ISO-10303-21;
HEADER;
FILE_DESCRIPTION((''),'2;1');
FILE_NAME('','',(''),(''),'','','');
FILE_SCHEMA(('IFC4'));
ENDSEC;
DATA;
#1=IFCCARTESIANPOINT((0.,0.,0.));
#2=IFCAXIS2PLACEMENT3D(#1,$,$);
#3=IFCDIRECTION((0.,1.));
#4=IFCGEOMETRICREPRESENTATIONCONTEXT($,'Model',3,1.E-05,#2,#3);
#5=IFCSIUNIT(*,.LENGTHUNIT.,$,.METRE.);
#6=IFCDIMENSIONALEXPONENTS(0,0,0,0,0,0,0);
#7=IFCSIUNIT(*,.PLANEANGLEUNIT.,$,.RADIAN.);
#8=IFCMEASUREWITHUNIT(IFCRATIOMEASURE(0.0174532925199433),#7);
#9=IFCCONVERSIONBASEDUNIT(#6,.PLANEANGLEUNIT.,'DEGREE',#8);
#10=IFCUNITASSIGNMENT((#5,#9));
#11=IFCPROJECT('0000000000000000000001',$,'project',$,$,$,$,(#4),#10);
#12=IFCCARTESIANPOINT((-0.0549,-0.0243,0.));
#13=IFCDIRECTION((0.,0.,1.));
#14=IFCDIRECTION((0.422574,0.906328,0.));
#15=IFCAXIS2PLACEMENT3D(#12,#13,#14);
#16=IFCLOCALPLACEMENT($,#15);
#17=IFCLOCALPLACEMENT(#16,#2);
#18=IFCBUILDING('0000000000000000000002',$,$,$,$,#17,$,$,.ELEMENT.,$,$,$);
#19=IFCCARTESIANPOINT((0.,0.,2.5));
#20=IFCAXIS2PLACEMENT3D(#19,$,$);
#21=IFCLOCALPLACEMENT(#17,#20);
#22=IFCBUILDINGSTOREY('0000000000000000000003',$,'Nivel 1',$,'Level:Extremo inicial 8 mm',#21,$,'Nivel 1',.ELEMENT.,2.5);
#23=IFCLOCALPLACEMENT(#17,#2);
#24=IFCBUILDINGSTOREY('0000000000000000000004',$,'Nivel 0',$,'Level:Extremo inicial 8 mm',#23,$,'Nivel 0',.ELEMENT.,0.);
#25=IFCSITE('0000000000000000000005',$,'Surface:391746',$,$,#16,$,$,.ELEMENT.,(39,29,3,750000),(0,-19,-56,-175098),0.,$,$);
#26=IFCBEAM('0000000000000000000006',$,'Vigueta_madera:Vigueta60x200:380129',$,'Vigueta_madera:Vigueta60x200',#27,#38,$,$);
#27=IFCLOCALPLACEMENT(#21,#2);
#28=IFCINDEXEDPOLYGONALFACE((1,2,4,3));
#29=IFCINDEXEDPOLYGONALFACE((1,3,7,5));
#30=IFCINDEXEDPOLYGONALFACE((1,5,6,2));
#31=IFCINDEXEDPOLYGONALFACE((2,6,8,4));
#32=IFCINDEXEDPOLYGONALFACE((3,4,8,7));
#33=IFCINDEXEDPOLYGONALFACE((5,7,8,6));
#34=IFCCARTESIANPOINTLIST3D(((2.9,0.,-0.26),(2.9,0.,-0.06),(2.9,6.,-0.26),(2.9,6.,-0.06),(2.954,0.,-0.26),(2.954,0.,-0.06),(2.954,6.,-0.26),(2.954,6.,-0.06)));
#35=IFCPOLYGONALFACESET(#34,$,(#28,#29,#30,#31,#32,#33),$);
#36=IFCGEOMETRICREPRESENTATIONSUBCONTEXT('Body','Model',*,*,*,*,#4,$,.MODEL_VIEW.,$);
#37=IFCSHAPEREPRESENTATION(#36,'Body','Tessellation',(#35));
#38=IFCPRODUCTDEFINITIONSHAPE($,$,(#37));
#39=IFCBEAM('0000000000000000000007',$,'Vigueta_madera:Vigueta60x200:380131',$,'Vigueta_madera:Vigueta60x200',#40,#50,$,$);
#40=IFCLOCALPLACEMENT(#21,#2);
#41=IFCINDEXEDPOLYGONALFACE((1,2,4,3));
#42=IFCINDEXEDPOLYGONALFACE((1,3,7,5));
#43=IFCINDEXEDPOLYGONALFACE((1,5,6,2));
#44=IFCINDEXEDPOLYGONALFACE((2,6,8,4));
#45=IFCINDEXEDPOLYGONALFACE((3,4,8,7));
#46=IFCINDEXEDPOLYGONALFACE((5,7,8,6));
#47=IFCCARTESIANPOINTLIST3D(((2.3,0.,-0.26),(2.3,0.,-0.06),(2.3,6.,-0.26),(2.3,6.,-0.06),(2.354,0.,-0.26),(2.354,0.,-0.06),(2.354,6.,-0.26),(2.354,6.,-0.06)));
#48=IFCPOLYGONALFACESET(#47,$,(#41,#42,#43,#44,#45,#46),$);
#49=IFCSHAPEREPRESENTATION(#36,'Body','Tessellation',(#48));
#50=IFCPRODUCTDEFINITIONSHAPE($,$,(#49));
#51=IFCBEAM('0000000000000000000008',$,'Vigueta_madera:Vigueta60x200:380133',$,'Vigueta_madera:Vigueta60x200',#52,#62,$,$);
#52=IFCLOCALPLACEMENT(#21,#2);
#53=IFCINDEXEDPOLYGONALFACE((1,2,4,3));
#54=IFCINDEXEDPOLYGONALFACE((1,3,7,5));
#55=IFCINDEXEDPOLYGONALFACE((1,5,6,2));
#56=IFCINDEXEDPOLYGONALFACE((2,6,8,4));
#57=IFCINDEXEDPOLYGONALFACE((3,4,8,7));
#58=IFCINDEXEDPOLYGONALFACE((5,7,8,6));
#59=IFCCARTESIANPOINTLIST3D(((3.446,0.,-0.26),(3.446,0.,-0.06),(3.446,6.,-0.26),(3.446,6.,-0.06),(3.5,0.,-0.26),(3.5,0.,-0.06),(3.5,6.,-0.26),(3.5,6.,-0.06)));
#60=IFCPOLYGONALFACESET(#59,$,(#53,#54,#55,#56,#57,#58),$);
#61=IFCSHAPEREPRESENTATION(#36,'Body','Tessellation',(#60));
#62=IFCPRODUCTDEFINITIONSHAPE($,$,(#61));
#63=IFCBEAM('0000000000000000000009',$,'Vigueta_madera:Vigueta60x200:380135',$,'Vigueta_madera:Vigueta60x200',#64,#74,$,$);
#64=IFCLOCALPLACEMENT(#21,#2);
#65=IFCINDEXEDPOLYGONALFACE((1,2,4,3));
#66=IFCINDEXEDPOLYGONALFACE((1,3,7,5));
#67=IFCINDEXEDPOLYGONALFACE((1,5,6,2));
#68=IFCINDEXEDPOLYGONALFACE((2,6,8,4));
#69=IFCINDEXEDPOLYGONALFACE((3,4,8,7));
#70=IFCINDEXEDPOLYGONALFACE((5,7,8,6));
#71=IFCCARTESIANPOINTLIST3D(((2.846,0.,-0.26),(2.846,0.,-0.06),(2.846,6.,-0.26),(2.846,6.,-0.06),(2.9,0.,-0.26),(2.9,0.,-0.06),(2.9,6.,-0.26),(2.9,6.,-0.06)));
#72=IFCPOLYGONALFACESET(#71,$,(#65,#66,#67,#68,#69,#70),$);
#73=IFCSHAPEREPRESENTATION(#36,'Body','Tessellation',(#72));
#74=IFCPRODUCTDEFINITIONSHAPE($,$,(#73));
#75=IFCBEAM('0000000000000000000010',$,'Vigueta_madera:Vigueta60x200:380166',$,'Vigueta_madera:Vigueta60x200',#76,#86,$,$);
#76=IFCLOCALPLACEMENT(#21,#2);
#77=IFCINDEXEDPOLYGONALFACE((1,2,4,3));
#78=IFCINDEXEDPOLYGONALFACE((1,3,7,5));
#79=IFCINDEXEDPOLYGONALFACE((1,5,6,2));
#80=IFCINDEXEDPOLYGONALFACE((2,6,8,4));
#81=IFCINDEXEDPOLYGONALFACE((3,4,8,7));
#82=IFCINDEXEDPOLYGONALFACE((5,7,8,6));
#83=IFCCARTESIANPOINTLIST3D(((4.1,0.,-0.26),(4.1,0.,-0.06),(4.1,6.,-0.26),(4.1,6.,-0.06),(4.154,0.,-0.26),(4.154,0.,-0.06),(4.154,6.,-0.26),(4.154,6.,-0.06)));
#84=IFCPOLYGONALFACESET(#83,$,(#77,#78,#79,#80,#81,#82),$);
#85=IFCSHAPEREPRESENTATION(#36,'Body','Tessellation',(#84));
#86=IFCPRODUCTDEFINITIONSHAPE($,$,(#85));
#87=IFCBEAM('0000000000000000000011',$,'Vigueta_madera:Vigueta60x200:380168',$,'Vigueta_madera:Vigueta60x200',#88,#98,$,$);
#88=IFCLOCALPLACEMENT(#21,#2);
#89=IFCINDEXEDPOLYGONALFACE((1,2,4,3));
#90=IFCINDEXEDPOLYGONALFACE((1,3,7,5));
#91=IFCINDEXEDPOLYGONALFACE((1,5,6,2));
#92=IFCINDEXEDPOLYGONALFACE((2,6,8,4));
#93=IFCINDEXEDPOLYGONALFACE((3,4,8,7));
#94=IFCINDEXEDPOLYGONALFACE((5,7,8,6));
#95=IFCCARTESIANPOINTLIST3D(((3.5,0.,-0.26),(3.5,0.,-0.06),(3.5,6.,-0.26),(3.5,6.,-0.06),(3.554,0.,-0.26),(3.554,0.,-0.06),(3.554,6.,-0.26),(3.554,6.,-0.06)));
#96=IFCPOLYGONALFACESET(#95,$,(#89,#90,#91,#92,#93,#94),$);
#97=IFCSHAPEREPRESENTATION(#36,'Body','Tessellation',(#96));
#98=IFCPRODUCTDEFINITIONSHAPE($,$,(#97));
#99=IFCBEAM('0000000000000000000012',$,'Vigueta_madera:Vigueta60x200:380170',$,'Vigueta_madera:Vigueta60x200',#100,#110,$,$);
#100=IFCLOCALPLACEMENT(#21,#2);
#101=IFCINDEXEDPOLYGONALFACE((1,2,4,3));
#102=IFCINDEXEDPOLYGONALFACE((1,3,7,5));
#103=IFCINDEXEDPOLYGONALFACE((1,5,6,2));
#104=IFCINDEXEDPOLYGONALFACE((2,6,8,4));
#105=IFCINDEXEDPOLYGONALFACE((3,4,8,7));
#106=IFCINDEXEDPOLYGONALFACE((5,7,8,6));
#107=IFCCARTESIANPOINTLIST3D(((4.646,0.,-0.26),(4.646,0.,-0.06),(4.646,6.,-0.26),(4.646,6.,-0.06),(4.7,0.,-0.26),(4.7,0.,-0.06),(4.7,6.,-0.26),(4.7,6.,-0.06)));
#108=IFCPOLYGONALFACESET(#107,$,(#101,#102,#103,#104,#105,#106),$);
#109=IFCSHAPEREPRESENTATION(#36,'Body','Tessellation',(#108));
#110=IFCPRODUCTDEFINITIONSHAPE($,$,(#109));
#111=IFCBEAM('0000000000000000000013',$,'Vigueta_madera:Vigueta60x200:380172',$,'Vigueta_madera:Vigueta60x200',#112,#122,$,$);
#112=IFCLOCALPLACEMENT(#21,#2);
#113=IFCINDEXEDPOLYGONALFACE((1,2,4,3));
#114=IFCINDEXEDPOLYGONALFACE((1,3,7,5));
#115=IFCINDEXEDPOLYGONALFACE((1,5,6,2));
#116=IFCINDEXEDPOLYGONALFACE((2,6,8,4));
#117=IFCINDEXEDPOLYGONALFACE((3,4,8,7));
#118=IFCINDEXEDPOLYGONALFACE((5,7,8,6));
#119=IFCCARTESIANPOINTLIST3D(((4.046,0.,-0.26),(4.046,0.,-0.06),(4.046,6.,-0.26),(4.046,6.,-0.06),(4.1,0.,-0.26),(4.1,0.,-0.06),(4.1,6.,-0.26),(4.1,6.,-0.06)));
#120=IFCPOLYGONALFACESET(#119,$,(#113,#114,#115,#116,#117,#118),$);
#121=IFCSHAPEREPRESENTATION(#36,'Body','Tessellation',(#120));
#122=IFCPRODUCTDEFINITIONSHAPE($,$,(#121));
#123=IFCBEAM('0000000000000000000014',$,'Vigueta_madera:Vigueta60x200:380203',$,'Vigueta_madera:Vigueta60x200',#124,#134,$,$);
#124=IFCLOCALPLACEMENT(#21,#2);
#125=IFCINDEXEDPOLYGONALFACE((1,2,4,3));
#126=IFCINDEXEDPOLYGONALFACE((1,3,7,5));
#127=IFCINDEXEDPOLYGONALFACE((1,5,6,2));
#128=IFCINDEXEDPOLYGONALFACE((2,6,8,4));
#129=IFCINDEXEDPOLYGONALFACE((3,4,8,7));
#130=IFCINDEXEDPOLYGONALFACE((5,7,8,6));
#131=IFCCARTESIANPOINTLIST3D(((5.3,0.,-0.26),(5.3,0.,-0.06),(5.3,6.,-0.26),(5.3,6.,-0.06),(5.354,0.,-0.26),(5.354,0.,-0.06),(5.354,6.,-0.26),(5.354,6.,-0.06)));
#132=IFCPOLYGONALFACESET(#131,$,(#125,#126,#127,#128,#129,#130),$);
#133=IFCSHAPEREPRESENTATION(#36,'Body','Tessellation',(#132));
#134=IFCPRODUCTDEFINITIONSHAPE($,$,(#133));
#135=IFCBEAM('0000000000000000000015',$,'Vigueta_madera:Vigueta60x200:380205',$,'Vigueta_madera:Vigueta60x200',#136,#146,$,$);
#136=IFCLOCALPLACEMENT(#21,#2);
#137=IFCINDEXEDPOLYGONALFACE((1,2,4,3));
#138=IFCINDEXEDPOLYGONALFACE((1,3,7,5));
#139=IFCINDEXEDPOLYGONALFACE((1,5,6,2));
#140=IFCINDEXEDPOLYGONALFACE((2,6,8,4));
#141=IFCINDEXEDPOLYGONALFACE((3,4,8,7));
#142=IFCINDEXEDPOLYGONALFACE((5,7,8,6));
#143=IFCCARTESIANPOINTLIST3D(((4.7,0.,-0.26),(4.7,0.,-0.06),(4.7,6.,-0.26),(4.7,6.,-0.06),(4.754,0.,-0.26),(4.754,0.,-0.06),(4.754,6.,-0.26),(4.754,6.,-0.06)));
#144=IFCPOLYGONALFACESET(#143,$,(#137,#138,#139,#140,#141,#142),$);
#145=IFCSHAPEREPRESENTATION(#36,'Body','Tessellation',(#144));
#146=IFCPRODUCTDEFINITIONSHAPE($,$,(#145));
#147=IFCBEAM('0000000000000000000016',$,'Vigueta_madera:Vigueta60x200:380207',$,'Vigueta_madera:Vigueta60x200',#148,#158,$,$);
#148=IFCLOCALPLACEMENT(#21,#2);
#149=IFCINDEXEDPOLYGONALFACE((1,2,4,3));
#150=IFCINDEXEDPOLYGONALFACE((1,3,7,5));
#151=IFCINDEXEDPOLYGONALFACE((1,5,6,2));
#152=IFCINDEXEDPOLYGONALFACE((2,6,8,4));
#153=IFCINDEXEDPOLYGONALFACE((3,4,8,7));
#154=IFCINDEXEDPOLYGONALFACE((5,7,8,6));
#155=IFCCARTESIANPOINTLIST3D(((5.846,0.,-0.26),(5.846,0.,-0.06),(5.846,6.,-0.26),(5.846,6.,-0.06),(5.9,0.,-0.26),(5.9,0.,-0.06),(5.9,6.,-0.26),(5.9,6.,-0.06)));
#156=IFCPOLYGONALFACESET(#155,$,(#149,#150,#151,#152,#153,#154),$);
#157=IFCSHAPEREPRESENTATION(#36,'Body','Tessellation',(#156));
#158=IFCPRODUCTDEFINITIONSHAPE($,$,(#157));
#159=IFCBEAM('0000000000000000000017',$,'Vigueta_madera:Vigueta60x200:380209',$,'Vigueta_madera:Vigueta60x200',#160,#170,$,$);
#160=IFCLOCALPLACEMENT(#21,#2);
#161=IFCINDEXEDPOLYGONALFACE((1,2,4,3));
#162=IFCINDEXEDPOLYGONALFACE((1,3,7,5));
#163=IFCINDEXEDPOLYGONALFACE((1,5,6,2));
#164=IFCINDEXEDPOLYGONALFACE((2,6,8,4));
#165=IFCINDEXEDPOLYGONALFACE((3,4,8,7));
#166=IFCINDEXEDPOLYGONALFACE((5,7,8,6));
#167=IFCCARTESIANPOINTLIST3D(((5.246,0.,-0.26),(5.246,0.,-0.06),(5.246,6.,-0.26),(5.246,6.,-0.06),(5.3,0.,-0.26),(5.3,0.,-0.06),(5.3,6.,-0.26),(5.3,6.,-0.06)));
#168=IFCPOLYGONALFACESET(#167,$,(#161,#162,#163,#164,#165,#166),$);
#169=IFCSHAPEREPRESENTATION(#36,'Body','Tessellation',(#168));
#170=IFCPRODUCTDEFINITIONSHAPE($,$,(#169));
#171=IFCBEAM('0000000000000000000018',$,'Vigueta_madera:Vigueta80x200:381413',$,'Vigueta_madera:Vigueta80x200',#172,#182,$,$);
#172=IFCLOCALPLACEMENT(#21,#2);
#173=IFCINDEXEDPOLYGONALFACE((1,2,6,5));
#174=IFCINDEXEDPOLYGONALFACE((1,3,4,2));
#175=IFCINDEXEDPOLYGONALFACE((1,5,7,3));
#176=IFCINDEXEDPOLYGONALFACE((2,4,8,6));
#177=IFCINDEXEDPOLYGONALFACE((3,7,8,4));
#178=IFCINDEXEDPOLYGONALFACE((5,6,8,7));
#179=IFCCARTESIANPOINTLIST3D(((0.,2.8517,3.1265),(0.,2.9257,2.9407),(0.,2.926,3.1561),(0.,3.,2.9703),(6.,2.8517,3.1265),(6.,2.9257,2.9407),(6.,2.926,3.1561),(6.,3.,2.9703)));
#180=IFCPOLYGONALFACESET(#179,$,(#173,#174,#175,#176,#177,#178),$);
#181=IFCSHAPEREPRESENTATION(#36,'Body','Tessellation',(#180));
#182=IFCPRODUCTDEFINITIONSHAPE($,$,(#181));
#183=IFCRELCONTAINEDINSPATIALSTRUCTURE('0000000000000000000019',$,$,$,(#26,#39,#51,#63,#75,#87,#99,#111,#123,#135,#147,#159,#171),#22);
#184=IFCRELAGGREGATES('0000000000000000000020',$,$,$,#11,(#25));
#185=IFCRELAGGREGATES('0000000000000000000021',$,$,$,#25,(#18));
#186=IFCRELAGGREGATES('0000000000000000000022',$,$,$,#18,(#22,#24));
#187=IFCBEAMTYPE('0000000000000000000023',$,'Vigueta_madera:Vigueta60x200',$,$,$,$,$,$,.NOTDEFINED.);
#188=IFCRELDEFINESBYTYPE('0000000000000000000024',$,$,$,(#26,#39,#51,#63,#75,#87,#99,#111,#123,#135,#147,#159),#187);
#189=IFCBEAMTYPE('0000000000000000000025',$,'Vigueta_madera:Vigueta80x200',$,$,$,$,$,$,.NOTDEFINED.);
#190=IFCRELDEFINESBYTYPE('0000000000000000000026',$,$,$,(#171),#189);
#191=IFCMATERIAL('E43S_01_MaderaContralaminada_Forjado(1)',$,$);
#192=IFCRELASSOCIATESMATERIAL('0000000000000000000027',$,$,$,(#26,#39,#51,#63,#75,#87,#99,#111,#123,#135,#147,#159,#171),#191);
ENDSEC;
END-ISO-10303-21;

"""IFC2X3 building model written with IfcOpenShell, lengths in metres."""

from ifc_helpers import new_model, entity, si_unit, converted_unit, direction, frame, frame_2d, origin, place, context, subcontext, project, spatial, rectangle, extrude, material, type_object, element, save


model = new_model("IFC2X3")

# Units and contexts
model_context = context("Model", 3, precision=1e-05, world=origin(), true_north=direction((0.0, 1.0)))
body_context = subcontext(model_context, "Body", "Model", "MODEL_VIEW")
ifc_project = project(units=[si_unit("LENGTHUNIT", "METRE"), converted_unit("PLANEANGLEUNIT", "DEGREE", entity("IfcRatioMeasure", 0.0174532925199433), si_unit("PLANEANGLEUNIT", "RADIAN"), dimensions=[0, 0, 0, 0, 0, 0, 0])], contexts=[model_context])

# Site, building, storey
site_placement = place(None, frame((-0.0549, -0.0243, 0.0), z_axis=(0.0, 0.0, 1.0), x_axis=(0.422574, 0.906328, 0.0)))
site = spatial("IfcSite", under=ifc_project, at=site_placement, Name="Surface:391746", CompositionType="ELEMENT", RefLatitude=(39, 29, 3, 750000), RefLongitude=(0, -19, -56, -175098), RefElevation=0.0)
building_placement = place(site_placement, origin())
building = spatial("IfcBuilding", under=site, at=building_placement, CompositionType="ELEMENT")
storey_1_placement = place(building_placement, frame((0.0, 0.0, 2.5)))
storey_1 = spatial("IfcBuildingStorey", under=building, at=storey_1_placement, Name="Nivel 1", ObjectType="Level:Extremo inicial 8 mm", LongName="Nivel 1", CompositionType="ELEMENT", Elevation=2.5)

# Beams
ifc_material_1 = material(Name="E43S_01_MaderaContralaminada_Forjado(1)")
beam_type_1 = type_object("IfcBeamType", Name="Vigueta_madera:Vigueta60x200", PredefinedType="NOTDEFINED")
beam_1_placement = place(storey_1_placement, frame((2.927, 0.0, -0.06), z_axis=(0.0, 0.0, 1.0), x_axis=(0.0, 1.0, 0.0)))
element("IfcBeam", 1, at=beam_1_placement, inside=storey_1, type_object=beam_type_1, material=ifc_material_1, Name="Vigueta_madera:Vigueta60x200:380129", ObjectType="Vigueta_madera:Vigueta60x200", context=body_context, shape_type="SweptSolid", body=[
    extrude(rectangle(XDim=0.2, YDim=0.054, at=frame_2d((0.0, 0.0), x_axis=(1.0, 0.0))), frame((0.0, 0.0, -0.1), z_axis=(1.0, 0.0, 0.0), x_axis=(0.0, 0.0, -1.0)), (0.0, 0.0, 1.0), 6.0),
])
for number, where, z_axis, x_axis, name in (
    (2, (2.327, 0.0, -0.06), (0.0, 0.0, 1.0), (0.0, 1.0, 0.0), "Vigueta_madera:Vigueta60x200:380131"),
    (3, (3.473, 0.0, -0.06), (0.0, 0.0, 1.0), (0.0, 1.0, 0.0), "Vigueta_madera:Vigueta60x200:380133"),
):
    element("IfcBeam", number, at=place(storey_1_placement, frame(where, z_axis=z_axis, x_axis=x_axis)), inside=storey_1, type_object=beam_type_1, material=ifc_material_1, Name=name, ObjectType="Vigueta_madera:Vigueta60x200", context=body_context, shape_type="SweptSolid", body=[
        extrude(rectangle(XDim=0.2, YDim=0.054, at=frame_2d((0.0, 0.0), x_axis=(1.0, 0.0))), frame((0.0, 0.0, -0.1), z_axis=(1.0, 0.0, 0.0), x_axis=(0.0, 0.0, -1.0)), (0.0, 0.0, 1.0), 6.0),
    ])
for number, where, z_axis, x_axis, name in (
    (4, (2.873, 0.0, -0.06), (0.0, 0.0, 1.0), (0.0, 1.0, 0.0), "Vigueta_madera:Vigueta60x200:380135"),
    (5, (4.127, 0.0, -0.06), (0.0, 0.0, 1.0), (0.0, 1.0, 0.0), "Vigueta_madera:Vigueta60x200:380166"),
):
    element("IfcBeam", number, at=place(storey_1_placement, frame(where, z_axis=z_axis, x_axis=x_axis)), inside=storey_1, type_object=beam_type_1, material=ifc_material_1, Name=name, ObjectType="Vigueta_madera:Vigueta60x200", context=body_context, shape_type="SweptSolid", body=[
        extrude(rectangle(XDim=0.2, YDim=0.054, at=frame_2d((0.0, 0.0), x_axis=(1.0, 0.0))), frame((0.0, 0.0, -0.1), z_axis=(1.0, 0.0, 0.0), x_axis=(0.0, 0.0, -1.0)), (0.0, 0.0, 1.0), 6.0),
    ])
beam_2_placement = place(storey_1_placement, frame((3.527, 0.0, -0.06), z_axis=(0.0, 0.0, 1.0), x_axis=(0.0, 1.0, 0.0)))
element("IfcBeam", 6, at=beam_2_placement, inside=storey_1, type_object=beam_type_1, material=ifc_material_1, Name="Vigueta_madera:Vigueta60x200:380168", ObjectType="Vigueta_madera:Vigueta60x200", context=body_context, shape_type="SweptSolid", body=[
    extrude(rectangle(XDim=0.2, YDim=0.054, at=frame_2d((0.0, 0.0), x_axis=(1.0, 0.0))), frame((0.0, 0.0, -0.1), z_axis=(1.0, 0.0, 0.0), x_axis=(0.0, 0.0, -1.0)), (0.0, 0.0, 1.0), 6.0),
])
beam_3_placement = place(storey_1_placement, frame((4.673, 0.0, -0.06), z_axis=(0.0, 0.0, 1.0), x_axis=(0.0, 1.0, 0.0)))
element("IfcBeam", 7, at=beam_3_placement, inside=storey_1, type_object=beam_type_1, material=ifc_material_1, Name="Vigueta_madera:Vigueta60x200:380170", ObjectType="Vigueta_madera:Vigueta60x200", context=body_context, shape_type="SweptSolid", body=[
    extrude(rectangle(XDim=0.2, YDim=0.054, at=frame_2d((0.0, 0.0), x_axis=(1.0, 0.0))), frame((0.0, 0.0, -0.1), z_axis=(1.0, 0.0, 0.0), x_axis=(0.0, 0.0, -1.0)), (0.0, 0.0, 1.0), 6.0),
])
beam_4_placement = place(storey_1_placement, frame((4.073, 0.0, -0.06), z_axis=(0.0, 0.0, 1.0), x_axis=(0.0, 1.0, 0.0)))
element("IfcBeam", 8, at=beam_4_placement, inside=storey_1, type_object=beam_type_1, material=ifc_material_1, Name="Vigueta_madera:Vigueta60x200:380172", ObjectType="Vigueta_madera:Vigueta60x200", context=body_context, shape_type="SweptSolid", body=[
    extrude(rectangle(XDim=0.2, YDim=0.054, at=frame_2d((0.0, 0.0), x_axis=(1.0, 0.0))), frame((0.0, 0.0, -0.1), z_axis=(1.0, 0.0, 0.0), x_axis=(0.0, 0.0, -1.0)), (0.0, 0.0, 1.0), 6.0),
])
beam_5_placement = place(storey_1_placement, frame((5.327, 0.0, -0.06), z_axis=(0.0, 0.0, 1.0), x_axis=(0.0, 1.0, 0.0)))
element("IfcBeam", 9, at=beam_5_placement, inside=storey_1, type_object=beam_type_1, material=ifc_material_1, Name="Vigueta_madera:Vigueta60x200:380203", ObjectType="Vigueta_madera:Vigueta60x200", context=body_context, shape_type="SweptSolid", body=[
    extrude(rectangle(XDim=0.2, YDim=0.054, at=frame_2d((0.0, 0.0), x_axis=(1.0, 0.0))), frame((0.0, 0.0, -0.1), z_axis=(1.0, 0.0, 0.0), x_axis=(0.0, 0.0, -1.0)), (0.0, 0.0, 1.0), 6.0),
])
beam_6_placement = place(storey_1_placement, frame((4.727, 0.0, -0.06), z_axis=(0.0, 0.0, 1.0), x_axis=(0.0, 1.0, 0.0)))
element("IfcBeam", 10, at=beam_6_placement, inside=storey_1, type_object=beam_type_1, material=ifc_material_1, Name="Vigueta_madera:Vigueta60x200:380205", ObjectType="Vigueta_madera:Vigueta60x200", context=body_context, shape_type="SweptSolid", body=[
    extrude(rectangle(XDim=0.2, YDim=0.054, at=frame_2d((0.0, 0.0), x_axis=(1.0, 0.0))), frame((0.0, 0.0, -0.1), z_axis=(1.0, 0.0, 0.0), x_axis=(0.0, 0.0, -1.0)), (0.0, 0.0, 1.0), 6.0),
])
beam_7_placement = place(storey_1_placement, frame((5.873, 0.0, -0.06), z_axis=(0.0, 0.0, 1.0), x_axis=(0.0, 1.0, 0.0)))
element("IfcBeam", 11, at=beam_7_placement, inside=storey_1, type_object=beam_type_1, material=ifc_material_1, Name="Vigueta_madera:Vigueta60x200:380207", ObjectType="Vigueta_madera:Vigueta60x200", context=body_context, shape_type="SweptSolid", body=[
    extrude(rectangle(XDim=0.2, YDim=0.054, at=frame_2d((0.0, 0.0), x_axis=(1.0, 0.0))), frame((0.0, 0.0, -0.1), z_axis=(1.0, 0.0, 0.0), x_axis=(0.0, 0.0, -1.0)), (0.0, 0.0, 1.0), 6.0),
])
beam_8_placement = place(storey_1_placement, frame((5.273, 0.0, -0.06), z_axis=(0.0, 0.0, 1.0), x_axis=(0.0, 1.0, 0.0)))
element("IfcBeam", 12, at=beam_8_placement, inside=storey_1, type_object=beam_type_1, material=ifc_material_1, Name="Vigueta_madera:Vigueta60x200:380209", ObjectType="Vigueta_madera:Vigueta60x200", context=body_context, shape_type="SweptSolid", body=[
    extrude(rectangle(XDim=0.2, YDim=0.054, at=frame_2d((0.0, 0.0), x_axis=(1.0, 0.0))), frame((0.0, 0.0, -0.1), z_axis=(1.0, 0.0, 0.0), x_axis=(0.0, 0.0, -1.0)), (0.0, 0.0, 1.0), 6.0),
])
beam_type_2 = type_object("IfcBeamType", Name="Vigueta_madera:Vigueta80x200", PredefinedType="NOTDEFINED")
beam_9_placement = place(storey_1_placement, frame((0.0, 2.8888, 3.1413)))
element("IfcBeam", 13, at=beam_9_placement, inside=storey_1, type_object=beam_type_2, material=ifc_material_1, Name="Vigueta_madera:Vigueta80x200:381413", ObjectType="Vigueta_madera:Vigueta80x200", context=body_context, shape_type="SweptSolid", body=[
    extrude(rectangle(XDim=0.2, YDim=0.08, at=frame_2d((0.0, 0.0), x_axis=(1.0, 0.0))), frame((0.0, 0.037, -0.0929), z_axis=(1.0, 0.0, 0.0), x_axis=(0.0, -0.370233, 0.928939)), (0.0, 0.0, 1.0), 6.0),
])

# Shared definitions
storey_2_placement = place(building_placement, origin())
storey_2 = spatial("IfcBuildingStorey", under=building, at=storey_2_placement, Name="Nivel 0", ObjectType="Level:Extremo inicial 8 mm", LongName="Nivel 0", CompositionType="ELEMENT", Elevation=0.0)

save(model, "model.ifc")
